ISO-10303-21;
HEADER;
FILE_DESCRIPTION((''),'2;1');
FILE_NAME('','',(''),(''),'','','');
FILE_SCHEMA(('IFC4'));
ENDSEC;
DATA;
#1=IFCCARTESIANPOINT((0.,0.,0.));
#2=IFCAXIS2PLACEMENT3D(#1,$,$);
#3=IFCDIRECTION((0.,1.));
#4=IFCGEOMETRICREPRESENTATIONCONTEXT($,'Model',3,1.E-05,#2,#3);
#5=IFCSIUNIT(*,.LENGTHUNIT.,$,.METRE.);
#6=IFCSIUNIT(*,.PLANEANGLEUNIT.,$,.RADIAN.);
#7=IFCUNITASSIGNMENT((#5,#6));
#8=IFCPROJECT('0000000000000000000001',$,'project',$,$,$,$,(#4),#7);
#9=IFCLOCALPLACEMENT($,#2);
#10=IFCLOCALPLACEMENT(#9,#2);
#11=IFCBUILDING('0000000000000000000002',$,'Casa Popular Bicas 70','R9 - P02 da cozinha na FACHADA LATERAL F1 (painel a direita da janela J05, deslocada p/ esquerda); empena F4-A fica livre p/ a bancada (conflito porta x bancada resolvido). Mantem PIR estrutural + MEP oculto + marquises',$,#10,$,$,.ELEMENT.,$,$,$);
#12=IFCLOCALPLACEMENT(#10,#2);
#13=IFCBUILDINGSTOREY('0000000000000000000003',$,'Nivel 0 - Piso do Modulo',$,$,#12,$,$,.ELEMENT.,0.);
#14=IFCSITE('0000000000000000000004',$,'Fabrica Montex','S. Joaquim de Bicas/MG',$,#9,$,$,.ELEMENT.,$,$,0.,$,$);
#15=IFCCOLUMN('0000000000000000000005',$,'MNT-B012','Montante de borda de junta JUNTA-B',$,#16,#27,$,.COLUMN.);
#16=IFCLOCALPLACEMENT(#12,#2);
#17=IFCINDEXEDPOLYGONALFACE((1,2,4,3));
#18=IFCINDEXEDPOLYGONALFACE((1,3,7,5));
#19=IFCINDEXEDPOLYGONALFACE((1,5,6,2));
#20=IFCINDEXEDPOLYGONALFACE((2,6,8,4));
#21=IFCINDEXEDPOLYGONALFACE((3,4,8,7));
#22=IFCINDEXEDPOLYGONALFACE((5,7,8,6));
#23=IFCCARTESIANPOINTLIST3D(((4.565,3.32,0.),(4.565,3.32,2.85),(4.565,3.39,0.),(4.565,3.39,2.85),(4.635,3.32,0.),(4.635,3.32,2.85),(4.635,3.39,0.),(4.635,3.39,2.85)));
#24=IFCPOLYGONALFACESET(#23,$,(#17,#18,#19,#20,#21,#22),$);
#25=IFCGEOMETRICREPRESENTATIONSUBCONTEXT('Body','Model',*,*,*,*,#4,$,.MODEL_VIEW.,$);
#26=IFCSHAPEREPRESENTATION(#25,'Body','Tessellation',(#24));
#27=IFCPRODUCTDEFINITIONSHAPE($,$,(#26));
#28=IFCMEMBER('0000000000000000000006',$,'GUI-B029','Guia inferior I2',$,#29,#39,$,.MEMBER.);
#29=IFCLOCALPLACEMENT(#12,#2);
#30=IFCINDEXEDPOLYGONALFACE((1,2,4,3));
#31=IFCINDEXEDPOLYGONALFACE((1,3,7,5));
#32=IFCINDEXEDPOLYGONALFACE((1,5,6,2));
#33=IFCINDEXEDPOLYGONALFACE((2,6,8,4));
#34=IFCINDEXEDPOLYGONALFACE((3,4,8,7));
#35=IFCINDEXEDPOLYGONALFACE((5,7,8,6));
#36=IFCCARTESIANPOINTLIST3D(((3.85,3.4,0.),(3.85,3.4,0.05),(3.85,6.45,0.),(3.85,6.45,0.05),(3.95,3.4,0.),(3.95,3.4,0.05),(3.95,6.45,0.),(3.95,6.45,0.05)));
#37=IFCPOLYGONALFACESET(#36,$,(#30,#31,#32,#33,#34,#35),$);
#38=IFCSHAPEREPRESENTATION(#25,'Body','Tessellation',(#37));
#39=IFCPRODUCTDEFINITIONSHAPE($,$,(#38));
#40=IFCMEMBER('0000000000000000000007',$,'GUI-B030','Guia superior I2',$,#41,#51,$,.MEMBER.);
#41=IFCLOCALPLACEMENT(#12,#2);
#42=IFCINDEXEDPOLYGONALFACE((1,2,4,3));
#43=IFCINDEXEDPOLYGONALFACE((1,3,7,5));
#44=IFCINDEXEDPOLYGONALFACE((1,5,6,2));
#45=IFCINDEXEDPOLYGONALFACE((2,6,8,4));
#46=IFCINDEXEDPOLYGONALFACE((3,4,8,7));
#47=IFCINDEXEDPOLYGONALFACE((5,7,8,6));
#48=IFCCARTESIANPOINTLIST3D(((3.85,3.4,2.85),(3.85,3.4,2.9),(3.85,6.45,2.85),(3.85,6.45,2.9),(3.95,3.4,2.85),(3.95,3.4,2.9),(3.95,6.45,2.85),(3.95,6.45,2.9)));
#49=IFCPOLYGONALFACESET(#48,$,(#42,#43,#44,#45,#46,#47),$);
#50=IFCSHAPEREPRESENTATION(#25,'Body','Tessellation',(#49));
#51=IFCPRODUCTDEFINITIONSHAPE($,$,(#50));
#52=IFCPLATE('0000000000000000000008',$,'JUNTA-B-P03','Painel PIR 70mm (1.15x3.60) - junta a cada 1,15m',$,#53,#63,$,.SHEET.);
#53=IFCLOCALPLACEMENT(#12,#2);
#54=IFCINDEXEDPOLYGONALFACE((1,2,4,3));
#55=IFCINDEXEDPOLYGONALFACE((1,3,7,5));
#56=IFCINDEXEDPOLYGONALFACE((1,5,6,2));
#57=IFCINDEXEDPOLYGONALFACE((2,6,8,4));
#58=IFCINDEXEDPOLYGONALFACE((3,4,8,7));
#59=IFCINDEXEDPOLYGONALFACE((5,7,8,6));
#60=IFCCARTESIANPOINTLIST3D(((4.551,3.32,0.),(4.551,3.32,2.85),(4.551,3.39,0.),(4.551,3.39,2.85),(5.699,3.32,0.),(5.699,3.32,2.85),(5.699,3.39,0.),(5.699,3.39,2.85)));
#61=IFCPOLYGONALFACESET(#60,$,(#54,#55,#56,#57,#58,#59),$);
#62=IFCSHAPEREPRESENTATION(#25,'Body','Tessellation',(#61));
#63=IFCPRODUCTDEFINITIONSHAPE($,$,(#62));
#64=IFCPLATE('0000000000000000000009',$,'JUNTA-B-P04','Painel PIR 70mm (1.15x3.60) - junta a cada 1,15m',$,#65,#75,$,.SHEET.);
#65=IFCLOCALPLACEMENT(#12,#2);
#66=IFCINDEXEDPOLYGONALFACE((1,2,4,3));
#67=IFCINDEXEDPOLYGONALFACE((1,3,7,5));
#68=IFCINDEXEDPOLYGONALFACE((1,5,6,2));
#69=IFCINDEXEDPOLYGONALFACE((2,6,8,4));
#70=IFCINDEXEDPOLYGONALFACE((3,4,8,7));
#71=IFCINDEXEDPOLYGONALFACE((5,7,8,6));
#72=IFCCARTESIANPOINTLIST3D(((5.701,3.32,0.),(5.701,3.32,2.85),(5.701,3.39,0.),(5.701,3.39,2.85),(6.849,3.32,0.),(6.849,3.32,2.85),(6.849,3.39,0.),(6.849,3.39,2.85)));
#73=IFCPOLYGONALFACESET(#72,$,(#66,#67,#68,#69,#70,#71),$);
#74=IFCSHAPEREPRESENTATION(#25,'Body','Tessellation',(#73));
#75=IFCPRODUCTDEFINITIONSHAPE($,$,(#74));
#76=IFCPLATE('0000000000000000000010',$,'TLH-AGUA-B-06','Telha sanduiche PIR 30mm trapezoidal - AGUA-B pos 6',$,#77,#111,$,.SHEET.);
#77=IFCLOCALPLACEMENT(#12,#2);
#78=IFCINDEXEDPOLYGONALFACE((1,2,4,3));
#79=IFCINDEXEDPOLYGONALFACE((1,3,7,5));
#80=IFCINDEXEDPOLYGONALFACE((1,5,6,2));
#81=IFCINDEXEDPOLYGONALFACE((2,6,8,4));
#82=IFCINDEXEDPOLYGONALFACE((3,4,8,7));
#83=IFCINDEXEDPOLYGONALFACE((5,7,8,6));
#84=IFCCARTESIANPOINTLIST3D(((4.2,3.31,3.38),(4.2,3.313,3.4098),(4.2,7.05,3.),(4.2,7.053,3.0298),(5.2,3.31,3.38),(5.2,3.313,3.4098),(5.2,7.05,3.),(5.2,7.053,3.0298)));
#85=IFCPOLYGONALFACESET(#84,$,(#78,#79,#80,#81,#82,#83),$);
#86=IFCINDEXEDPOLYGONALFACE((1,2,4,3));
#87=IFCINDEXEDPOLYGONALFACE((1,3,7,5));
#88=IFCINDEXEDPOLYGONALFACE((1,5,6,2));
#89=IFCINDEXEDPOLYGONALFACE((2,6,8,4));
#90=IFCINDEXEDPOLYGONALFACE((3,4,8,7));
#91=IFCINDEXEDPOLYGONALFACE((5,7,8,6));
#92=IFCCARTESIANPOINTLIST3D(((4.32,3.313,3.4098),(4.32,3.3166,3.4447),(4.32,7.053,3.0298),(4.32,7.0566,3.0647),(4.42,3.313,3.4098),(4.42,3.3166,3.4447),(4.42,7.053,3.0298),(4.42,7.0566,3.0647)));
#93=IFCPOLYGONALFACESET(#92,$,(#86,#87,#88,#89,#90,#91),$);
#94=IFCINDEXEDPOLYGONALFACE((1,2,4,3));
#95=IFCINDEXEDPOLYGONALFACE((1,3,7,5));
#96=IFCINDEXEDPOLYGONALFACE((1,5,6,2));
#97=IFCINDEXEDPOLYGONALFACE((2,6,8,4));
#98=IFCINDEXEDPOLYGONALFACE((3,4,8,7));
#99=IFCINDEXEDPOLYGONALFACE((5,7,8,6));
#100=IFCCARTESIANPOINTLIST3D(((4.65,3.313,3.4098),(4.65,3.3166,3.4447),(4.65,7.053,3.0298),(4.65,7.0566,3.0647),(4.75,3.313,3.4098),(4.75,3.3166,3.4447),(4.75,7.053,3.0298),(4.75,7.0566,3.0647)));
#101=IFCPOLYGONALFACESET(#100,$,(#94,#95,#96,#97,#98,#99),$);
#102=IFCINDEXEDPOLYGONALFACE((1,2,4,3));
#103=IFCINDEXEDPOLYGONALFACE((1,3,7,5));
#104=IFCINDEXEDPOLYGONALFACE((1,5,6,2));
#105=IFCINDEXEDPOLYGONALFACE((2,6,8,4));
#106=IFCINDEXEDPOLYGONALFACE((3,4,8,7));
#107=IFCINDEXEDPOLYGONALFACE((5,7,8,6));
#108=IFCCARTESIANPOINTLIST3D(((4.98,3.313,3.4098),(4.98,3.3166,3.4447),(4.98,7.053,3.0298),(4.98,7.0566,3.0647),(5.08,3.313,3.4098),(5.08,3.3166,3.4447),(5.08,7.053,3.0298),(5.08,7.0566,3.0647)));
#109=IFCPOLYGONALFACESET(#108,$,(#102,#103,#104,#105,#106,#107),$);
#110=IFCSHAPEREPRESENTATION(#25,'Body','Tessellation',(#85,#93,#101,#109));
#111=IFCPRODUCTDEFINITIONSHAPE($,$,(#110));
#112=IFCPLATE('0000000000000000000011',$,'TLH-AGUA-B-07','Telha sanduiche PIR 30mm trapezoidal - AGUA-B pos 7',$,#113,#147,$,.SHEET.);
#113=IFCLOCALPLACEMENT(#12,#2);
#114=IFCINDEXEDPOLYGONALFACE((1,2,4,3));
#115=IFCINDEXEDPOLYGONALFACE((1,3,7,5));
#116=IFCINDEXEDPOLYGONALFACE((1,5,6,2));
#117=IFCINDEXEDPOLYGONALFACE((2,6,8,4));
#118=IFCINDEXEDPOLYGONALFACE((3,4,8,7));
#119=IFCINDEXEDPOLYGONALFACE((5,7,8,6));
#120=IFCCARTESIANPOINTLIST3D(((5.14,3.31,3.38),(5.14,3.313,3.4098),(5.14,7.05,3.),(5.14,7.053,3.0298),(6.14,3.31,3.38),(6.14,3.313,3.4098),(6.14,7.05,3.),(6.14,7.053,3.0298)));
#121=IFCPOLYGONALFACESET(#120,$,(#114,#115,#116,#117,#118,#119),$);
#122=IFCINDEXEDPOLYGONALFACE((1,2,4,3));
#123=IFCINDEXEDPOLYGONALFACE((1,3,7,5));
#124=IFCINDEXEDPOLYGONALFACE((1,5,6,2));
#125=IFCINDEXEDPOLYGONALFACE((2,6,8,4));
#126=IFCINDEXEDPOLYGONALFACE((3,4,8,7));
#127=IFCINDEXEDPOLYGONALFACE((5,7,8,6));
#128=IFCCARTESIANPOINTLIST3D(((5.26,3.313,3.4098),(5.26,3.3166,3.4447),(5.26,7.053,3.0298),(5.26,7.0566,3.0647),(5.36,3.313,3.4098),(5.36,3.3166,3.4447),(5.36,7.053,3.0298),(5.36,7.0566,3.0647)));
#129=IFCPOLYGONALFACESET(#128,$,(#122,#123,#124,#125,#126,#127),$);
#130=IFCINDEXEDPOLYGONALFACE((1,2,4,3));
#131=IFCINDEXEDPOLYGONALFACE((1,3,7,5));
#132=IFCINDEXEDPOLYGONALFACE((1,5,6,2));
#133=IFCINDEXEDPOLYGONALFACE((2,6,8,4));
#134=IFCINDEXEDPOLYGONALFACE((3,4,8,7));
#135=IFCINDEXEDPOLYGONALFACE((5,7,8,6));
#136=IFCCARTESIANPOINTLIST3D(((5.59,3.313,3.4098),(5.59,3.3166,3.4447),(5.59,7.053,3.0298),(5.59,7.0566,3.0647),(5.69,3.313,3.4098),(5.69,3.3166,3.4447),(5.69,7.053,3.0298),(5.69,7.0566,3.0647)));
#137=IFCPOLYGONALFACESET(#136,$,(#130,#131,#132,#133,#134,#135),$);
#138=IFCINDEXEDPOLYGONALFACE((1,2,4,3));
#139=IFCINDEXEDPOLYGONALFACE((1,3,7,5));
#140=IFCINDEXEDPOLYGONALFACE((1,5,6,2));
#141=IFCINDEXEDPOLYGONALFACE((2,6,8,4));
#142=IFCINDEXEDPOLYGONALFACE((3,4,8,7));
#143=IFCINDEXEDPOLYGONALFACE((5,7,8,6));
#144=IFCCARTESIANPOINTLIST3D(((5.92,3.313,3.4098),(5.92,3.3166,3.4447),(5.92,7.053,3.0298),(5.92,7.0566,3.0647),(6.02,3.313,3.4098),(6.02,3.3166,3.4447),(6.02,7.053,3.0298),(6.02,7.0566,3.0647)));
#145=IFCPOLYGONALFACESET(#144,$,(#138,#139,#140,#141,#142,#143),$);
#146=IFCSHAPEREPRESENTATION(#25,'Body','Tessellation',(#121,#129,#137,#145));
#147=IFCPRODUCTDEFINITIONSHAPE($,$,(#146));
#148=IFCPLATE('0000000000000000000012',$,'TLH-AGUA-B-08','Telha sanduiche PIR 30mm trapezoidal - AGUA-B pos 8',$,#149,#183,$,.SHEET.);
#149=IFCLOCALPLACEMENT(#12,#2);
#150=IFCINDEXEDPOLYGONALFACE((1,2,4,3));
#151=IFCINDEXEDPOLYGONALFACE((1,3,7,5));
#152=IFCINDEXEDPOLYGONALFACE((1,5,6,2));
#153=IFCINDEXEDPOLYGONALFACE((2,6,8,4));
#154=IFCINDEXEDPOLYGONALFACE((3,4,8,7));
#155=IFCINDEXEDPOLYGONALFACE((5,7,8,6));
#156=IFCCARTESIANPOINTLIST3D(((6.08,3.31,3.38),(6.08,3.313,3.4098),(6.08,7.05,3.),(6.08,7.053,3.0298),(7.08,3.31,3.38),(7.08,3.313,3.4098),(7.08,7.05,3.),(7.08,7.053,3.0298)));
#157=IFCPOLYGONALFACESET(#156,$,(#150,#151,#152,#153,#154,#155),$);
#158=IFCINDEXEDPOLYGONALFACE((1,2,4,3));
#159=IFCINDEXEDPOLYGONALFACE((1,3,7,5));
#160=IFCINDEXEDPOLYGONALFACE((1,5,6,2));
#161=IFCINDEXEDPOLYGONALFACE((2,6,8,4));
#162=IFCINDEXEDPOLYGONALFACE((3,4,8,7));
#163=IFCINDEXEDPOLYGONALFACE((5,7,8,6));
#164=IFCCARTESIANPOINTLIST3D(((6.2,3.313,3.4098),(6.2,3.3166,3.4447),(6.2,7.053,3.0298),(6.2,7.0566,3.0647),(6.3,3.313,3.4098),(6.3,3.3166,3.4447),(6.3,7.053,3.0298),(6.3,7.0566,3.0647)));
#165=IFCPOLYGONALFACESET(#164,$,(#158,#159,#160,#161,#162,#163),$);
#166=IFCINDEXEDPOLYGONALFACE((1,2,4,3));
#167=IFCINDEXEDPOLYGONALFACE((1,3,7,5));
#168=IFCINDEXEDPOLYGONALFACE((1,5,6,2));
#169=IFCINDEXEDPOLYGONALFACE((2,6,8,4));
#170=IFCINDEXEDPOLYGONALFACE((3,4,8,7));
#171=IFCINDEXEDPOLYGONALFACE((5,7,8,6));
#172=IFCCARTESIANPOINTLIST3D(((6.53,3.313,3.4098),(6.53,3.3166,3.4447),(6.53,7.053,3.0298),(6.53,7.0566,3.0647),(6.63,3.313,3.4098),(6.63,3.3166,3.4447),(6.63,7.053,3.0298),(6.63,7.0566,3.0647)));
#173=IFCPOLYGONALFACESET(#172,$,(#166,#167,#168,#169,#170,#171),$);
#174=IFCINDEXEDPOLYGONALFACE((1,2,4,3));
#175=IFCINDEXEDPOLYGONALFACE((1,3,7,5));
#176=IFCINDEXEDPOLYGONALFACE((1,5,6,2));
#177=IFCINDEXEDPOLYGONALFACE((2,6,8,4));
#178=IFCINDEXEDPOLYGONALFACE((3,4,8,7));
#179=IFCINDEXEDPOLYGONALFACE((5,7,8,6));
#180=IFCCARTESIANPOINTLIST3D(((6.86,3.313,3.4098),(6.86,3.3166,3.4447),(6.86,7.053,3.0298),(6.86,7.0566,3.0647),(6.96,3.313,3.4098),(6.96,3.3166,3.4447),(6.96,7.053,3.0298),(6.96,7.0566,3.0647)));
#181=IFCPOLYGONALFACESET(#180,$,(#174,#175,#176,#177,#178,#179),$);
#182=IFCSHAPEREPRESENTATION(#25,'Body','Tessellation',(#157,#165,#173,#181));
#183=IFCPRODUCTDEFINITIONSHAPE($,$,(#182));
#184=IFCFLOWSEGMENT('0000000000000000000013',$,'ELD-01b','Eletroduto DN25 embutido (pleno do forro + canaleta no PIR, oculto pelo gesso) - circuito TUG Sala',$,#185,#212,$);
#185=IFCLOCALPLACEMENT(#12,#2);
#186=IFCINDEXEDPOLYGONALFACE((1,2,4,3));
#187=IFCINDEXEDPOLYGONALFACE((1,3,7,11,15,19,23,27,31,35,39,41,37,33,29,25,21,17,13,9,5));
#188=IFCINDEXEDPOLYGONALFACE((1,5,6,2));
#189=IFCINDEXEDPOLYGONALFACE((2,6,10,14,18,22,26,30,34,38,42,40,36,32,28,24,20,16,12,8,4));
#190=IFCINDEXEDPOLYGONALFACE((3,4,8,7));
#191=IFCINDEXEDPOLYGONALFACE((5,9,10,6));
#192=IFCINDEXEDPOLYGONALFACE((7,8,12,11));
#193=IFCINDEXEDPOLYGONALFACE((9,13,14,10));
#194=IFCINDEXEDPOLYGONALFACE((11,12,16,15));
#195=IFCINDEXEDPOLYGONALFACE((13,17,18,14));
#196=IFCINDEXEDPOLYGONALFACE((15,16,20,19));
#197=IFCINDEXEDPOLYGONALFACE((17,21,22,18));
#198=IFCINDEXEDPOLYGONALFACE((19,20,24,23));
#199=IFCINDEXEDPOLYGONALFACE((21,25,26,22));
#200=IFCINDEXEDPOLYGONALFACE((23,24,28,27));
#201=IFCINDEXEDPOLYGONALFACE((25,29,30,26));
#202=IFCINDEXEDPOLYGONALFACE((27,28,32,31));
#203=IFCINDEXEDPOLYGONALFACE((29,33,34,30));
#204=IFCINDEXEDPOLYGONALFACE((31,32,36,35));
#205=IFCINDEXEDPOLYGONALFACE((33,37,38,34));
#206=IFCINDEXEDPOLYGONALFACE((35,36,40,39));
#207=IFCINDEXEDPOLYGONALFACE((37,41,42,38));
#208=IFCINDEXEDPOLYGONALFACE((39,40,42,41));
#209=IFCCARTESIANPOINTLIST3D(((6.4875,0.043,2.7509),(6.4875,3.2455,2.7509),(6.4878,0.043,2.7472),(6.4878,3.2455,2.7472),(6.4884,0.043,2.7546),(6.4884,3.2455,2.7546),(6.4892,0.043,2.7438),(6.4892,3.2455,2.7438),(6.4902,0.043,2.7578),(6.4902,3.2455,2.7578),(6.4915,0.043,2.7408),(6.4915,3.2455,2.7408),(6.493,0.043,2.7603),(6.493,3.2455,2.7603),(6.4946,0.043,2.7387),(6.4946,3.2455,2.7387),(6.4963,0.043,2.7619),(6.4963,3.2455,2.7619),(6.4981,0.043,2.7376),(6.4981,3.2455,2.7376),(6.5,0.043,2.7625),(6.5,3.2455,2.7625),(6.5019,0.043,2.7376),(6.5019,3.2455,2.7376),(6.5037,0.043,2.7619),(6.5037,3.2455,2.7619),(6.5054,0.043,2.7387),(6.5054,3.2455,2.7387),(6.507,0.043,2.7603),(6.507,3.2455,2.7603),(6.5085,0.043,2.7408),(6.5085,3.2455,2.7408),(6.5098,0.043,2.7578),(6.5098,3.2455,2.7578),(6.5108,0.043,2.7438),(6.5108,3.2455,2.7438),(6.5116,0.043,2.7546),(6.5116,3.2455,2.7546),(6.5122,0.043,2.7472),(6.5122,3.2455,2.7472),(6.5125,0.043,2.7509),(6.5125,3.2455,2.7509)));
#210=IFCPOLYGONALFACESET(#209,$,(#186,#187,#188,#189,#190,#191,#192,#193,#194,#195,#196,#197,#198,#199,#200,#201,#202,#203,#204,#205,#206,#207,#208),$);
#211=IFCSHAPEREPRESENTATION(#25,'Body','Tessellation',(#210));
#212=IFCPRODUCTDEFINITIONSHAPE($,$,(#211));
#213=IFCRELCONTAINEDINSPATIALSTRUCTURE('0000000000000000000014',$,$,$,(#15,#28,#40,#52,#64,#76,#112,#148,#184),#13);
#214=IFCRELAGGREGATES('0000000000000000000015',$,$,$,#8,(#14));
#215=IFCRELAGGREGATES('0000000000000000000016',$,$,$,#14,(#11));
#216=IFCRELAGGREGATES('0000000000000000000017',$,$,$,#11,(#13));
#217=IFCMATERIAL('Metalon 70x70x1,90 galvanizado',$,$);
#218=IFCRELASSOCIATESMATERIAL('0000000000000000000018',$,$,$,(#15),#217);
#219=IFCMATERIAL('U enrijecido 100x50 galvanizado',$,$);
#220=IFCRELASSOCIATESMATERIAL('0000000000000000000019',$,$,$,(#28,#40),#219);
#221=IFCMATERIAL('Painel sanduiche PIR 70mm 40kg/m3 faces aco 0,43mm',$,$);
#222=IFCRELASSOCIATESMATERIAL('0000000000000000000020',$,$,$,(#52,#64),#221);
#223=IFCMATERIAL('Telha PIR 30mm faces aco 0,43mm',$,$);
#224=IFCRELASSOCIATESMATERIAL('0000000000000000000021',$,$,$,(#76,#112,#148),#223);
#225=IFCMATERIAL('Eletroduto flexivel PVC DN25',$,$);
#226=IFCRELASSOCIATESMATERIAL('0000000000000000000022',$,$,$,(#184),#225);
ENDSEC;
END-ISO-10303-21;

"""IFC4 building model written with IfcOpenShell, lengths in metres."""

from ifc_helpers import new_model, si_unit, direction, frame, frame_2d, origin, origin_2d, place, context, subcontext, project, spatial, rectangle, circle, extrude, material, element, save


model = new_model("IFC4")

# Units and contexts
model_context_1 = context("Model", 3, precision=1e-05, world=origin(), true_north=direction((0.0, 1.0)))
body_context_1 = subcontext(model_context_1, "Body", "Model", "MODEL_VIEW")
ifc_project = project(units=[si_unit("LENGTHUNIT", "METRE"), si_unit("PLANEANGLEUNIT", "RADIAN")], contexts=[model_context_1])

# Site, building, storey
site_placement = place(None, origin())
site = spatial("IfcSite", under=ifc_project, at=site_placement, Name="Fabrica Montex", Description="S. Joaquim de Bicas/MG", CompositionType="ELEMENT", RefElevation=0.0)
building_placement = place(site_placement, origin())
building = spatial("IfcBuilding", under=site, at=building_placement, Name="Casa Popular Bicas 70", Description="R9 - P02 da cozinha na FACHADA LATERAL F1 (painel a direita da janela J05, deslocada p/ esquerda); empena F4-A fica livre p/ a bancada (conflito porta x bancada resolvido). Mantem PIR estrutural + MEP oculto + marquises", CompositionType="ELEMENT")
storey_placement = place(building_placement, origin())
storey = spatial("IfcBuildingStorey", under=building, at=storey_placement, Name="Nivel 0 - Piso do Modulo", CompositionType="ELEMENT", Elevation=0.0)

# Column
ifc_material_1 = material(Name="Metalon 70x70x1,90 galvanizado")
column_placement = place(storey_placement, frame((4.6, 3.355, 0.0)))
element("IfcColumn", 1, at=column_placement, inside=storey, material=ifc_material_1, Name="MNT-B012", Description="Montante de borda de junta JUNTA-B", PredefinedType="COLUMN", context=body_context_1, shape_type="SweptSolid", body=[
    extrude(rectangle(XDim=0.07, YDim=0.07, at=origin_2d()), origin(), (0.0, 0.0, 1.0), 2.85),
])

# Members
ifc_material_2 = material(Name="U enrijecido 100x50 galvanizado")
for number, where, z_axis, x_axis, name, description in (
    (2, (3.9, 3.4, 0.025), (0.0, 1.0, 0.0), (0.0, 0.0, 1.0), "GUI-B029", "Guia inferior I2"),
    (3, (3.9, 3.4, 2.875), (0.0, 1.0, 0.0), (0.0, 0.0, 1.0), "GUI-B030", "Guia superior I2"),
):
    element("IfcMember", number, at=place(storey_placement, frame(where, z_axis=z_axis, x_axis=x_axis)), inside=storey, material=ifc_material_2, Name=name, Description=description, PredefinedType="MEMBER", context=body_context_1, shape_type="SweptSolid", body=[
        extrude(rectangle(XDim=0.05, YDim=0.1, at=origin_2d()), origin(), (0.0, 0.0, 1.0), 3.05),
    ])

# Plates
ifc_material_3 = material(Name="Painel sanduiche PIR 70mm 40kg/m3 faces aco 0,43mm")
for number, where, x_axis, name in (
    (4, (4.551, 3.355, 0.0), (1.0, 0.0, 0.0), "JUNTA-B-P03"),
    (5, (5.701, 3.355, 0.0), (1.0, 0.0, 0.0), "JUNTA-B-P04"),
):
    element("IfcPlate", number, at=place(storey_placement, frame(where, x_axis=x_axis)), inside=storey, material=ifc_material_3, Name=name, Description="Painel PIR 70mm (1.15x3.60) - junta a cada 1,15m", PredefinedType="SHEET", context=body_context_1, shape_type="SweptSolid", body=[
        extrude(rectangle(XDim=1.148, YDim=0.07, at=frame_2d((0.574, 0.0))), origin(), (0.0, 0.0, 1.0), 2.85),
    ])
ifc_material_4 = material(Name="Telha PIR 30mm faces aco 0,43mm")
for number, where, z_axis, x_axis, name, description in (
    (6, (4.2, 3.31, 3.38), (0.0, 0.101084, 0.994878), (1.0, 0.0, 0.0), "TLH-AGUA-B-06", "Telha sanduiche PIR 30mm trapezoidal - AGUA-B pos 6"),
    (7, (5.14, 3.31, 3.38), (0.0, 0.101084, 0.994878), (1.0, 0.0, 0.0), "TLH-AGUA-B-07", "Telha sanduiche PIR 30mm trapezoidal - AGUA-B pos 7"),
    (8, (6.08, 3.31, 3.38), (0.0, 0.101084, 0.994878), (1.0, 0.0, 0.0), "TLH-AGUA-B-08", "Telha sanduiche PIR 30mm trapezoidal - AGUA-B pos 8"),
):
    element("IfcPlate", number, at=place(storey_placement, frame(where, z_axis=z_axis, x_axis=x_axis)), inside=storey, material=ifc_material_4, Name=name, Description=description, PredefinedType="SHEET", context=body_context_1, shape_type="SweptSolid", body=[
        extrude(rectangle(XDim=1.0, YDim=3.7593, at=frame_2d((0.5, 1.8796))), origin(), (0.0, 0.0, 1.0), 0.03),
        extrude(rectangle(XDim=0.1, YDim=3.7593, at=frame_2d((0.17, 1.8796))), frame((0.0, 0.0, 0.03)), (0.0, 0.0, 1.0), 0.035),
        extrude(rectangle(XDim=0.1, YDim=3.7593, at=frame_2d((0.5, 1.8796))), frame((0.0, 0.0, 0.03)), (0.0, 0.0, 1.0), 0.035),
        extrude(rectangle(XDim=0.1, YDim=3.7593, at=frame_2d((0.83, 1.8796))), frame((0.0, 0.0, 0.03)), (0.0, 0.0, 1.0), 0.035),
    ])

# Flow segment
ifc_material_5 = material(Name="Eletroduto flexivel PVC DN25")
for number, where, z_axis, x_axis, name in (
    (9, (6.5, 3.2455, 2.75), (0.0, -1.0, 0.0), (0.0, 0.0, 1.0), "ELD-01b"),
):
    element("IfcFlowSegment", number, at=place(storey_placement, frame(where, z_axis=z_axis, x_axis=x_axis)), inside=storey, material=ifc_material_5, Name=name, Description="Eletroduto DN25 embutido (pleno do forro + canaleta no PIR, oculto pelo gesso) - circuito TUG Sala", context=body_context_1, shape_type="SweptSolid", body=[
        extrude(circle(Radius=0.0125, at=origin_2d()), origin(), (0.0, 0.0, 1.0), 3.2025),
    ])

save(model, "model.ifc")
